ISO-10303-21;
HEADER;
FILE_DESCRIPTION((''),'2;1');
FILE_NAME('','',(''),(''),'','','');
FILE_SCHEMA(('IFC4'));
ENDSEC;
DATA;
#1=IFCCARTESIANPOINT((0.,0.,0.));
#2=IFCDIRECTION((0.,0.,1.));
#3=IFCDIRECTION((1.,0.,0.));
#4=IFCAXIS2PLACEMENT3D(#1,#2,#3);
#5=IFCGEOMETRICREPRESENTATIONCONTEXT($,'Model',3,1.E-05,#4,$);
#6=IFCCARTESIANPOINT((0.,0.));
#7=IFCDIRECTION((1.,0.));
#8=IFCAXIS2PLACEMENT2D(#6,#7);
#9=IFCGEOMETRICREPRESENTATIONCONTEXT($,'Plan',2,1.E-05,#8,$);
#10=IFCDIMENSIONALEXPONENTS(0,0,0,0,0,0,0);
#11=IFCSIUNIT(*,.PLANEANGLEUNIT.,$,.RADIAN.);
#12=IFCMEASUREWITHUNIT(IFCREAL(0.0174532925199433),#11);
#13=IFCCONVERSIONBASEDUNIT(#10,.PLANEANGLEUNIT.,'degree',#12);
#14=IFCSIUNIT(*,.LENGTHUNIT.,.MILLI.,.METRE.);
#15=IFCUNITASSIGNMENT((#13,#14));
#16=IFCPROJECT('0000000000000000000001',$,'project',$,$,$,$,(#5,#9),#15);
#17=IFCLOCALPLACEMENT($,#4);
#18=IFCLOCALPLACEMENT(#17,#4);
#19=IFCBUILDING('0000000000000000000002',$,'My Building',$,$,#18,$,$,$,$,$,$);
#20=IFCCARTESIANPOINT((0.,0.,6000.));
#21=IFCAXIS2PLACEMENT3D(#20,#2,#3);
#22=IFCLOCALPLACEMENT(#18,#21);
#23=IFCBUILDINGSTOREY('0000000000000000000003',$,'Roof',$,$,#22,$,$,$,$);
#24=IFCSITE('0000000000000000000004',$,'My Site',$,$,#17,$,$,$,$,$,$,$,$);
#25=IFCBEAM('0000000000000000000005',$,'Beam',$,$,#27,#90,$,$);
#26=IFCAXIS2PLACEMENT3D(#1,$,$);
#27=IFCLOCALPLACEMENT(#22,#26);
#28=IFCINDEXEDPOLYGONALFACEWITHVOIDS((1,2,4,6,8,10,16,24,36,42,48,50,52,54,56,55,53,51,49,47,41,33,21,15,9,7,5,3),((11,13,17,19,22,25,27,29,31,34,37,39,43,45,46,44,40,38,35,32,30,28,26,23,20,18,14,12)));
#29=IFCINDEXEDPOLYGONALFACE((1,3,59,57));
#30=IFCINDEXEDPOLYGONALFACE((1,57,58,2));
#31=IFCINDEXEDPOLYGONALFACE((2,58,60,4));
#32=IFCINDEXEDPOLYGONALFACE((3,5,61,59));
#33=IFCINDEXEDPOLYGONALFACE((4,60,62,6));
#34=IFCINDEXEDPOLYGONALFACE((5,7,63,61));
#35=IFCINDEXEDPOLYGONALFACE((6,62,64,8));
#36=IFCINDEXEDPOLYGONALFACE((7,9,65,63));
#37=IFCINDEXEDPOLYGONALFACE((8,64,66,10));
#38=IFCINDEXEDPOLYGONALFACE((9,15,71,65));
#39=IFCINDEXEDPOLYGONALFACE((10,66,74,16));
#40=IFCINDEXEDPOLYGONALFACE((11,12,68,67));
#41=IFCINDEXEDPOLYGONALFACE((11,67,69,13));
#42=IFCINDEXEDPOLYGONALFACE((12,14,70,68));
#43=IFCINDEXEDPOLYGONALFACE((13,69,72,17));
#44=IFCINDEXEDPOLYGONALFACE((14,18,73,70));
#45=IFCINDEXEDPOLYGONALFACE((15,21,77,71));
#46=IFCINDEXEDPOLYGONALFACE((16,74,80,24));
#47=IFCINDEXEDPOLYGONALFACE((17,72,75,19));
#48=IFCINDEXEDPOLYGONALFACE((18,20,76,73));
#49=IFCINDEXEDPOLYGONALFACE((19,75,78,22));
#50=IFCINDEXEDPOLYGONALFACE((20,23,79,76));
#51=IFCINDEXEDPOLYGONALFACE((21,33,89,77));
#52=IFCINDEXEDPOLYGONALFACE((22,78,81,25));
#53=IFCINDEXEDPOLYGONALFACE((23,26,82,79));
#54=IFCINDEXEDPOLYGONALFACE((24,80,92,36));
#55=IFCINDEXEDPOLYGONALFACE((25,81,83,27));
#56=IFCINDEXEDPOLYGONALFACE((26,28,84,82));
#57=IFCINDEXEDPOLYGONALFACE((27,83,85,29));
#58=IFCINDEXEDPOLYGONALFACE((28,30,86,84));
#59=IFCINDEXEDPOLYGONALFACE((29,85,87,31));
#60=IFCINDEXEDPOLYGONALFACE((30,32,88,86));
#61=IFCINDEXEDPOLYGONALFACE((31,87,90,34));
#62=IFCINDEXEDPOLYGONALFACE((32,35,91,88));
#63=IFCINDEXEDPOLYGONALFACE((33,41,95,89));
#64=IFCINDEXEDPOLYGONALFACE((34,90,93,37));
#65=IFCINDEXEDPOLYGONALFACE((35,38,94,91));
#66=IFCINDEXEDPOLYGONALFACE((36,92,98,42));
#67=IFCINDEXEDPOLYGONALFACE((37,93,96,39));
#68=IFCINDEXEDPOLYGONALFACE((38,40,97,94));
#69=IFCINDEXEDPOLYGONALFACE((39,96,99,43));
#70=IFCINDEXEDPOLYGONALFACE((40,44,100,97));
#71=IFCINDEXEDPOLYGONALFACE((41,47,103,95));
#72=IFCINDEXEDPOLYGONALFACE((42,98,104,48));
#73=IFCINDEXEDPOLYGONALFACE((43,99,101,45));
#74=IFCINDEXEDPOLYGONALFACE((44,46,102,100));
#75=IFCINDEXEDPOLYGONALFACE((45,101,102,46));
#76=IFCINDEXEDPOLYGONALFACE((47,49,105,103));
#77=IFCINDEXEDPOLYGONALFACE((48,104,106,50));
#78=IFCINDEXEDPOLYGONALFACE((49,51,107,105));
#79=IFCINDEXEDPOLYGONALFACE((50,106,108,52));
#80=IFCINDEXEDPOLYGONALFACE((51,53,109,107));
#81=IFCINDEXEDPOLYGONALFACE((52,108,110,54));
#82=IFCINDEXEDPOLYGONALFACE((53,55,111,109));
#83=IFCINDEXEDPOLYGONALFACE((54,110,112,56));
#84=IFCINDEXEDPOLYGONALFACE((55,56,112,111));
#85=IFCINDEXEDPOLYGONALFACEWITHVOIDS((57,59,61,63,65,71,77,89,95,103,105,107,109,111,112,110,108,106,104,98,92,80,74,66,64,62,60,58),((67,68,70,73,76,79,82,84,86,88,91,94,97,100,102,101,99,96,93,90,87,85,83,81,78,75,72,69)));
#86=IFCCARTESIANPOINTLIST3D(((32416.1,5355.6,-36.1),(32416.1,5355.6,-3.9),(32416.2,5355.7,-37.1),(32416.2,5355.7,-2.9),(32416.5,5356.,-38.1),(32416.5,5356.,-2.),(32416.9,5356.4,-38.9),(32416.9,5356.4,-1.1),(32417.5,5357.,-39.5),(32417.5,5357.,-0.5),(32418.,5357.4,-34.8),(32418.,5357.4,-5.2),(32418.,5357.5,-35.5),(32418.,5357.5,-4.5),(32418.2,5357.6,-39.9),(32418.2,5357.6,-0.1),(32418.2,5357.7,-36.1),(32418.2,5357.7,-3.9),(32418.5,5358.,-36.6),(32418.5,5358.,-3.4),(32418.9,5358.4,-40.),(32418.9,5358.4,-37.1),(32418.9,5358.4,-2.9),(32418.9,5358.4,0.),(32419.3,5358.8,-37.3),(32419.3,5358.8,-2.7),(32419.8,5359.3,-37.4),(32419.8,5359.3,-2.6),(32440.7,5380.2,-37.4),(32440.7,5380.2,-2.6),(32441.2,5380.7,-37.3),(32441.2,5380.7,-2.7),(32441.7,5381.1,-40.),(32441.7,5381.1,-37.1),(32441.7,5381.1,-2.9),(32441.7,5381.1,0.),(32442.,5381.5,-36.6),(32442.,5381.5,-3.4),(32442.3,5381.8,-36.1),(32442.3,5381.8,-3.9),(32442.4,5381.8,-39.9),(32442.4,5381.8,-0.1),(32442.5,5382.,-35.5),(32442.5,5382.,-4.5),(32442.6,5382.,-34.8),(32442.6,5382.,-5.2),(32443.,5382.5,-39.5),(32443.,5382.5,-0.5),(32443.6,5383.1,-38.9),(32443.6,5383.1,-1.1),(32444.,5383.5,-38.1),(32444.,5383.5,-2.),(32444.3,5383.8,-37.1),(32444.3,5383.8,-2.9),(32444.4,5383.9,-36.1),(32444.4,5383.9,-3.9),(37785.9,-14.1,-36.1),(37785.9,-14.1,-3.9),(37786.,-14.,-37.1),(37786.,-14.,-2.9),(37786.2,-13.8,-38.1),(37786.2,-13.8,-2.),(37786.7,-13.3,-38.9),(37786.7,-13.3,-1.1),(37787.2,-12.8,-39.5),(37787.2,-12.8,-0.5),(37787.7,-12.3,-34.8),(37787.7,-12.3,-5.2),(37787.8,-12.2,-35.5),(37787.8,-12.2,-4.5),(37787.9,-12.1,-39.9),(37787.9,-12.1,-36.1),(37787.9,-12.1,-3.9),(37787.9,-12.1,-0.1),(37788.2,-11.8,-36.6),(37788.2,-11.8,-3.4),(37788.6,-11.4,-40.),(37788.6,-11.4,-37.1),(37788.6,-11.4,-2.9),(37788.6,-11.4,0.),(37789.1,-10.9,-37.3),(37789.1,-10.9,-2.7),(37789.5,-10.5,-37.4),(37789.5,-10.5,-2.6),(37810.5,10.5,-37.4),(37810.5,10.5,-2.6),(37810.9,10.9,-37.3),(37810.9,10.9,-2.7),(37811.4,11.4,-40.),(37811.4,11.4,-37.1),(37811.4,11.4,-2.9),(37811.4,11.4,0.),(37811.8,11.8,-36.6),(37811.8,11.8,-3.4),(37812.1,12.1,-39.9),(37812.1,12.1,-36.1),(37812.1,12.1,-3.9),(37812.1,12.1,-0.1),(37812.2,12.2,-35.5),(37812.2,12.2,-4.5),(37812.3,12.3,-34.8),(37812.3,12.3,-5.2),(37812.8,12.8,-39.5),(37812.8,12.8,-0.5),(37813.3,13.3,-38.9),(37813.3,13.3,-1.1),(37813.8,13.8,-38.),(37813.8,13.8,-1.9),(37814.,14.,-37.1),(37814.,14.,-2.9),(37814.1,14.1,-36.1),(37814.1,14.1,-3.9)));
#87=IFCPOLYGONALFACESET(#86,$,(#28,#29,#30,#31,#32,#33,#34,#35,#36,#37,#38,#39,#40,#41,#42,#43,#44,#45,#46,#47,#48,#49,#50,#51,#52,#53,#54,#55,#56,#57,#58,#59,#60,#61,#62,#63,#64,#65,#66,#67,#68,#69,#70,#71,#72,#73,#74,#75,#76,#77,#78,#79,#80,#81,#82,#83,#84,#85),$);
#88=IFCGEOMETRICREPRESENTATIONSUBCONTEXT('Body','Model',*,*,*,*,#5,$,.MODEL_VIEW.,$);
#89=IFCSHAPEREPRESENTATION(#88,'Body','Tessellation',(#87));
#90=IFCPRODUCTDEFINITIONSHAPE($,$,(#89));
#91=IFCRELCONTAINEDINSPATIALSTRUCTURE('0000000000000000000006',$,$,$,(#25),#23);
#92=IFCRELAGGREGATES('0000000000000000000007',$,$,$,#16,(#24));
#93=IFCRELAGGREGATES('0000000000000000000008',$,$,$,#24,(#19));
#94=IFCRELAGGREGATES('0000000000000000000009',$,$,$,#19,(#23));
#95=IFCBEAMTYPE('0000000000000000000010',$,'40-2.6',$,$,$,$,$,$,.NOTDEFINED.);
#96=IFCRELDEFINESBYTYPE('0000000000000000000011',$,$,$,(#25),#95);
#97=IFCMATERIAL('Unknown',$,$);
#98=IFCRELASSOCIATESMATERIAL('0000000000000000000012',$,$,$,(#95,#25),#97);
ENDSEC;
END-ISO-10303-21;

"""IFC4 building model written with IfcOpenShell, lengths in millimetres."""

from ifc_helpers import new_model, entity, si_unit, converted_unit, frame, origin_with_axes, origin_2d_with_axis, place, context, subcontext, project, spatial, hollow_rectangle, extrude, material, material_profile, profile_set, profile_usage, type_object, element, save


model = new_model("IFC4")

# Units and contexts
model_context = context("Model", 3, precision=1e-05, world=origin_with_axes())
plan_context = context("Plan", 2, precision=1e-05, world=origin_2d_with_axis())
body_context = subcontext(model_context, "Body", "Model", "MODEL_VIEW")
ifc_project = project(units=[converted_unit("PLANEANGLEUNIT", "degree", entity("IfcReal", 0.0174532925199433), si_unit("PLANEANGLEUNIT", "RADIAN"), dimensions=[0, 0, 0, 0, 0, 0, 0]), si_unit("LENGTHUNIT", "METRE", prefix="MILLI")], contexts=[model_context, plan_context])

# Site, building, storey
site_placement = place(None, origin_with_axes())
site = spatial("IfcSite", under=ifc_project, at=site_placement, Name="My Site")
building_placement = place(site_placement, origin_with_axes())
building = spatial("IfcBuilding", under=site, at=building_placement, Name="My Building")
storey_placement = place(building_placement, frame((0.0, 0.0, 6000.0), z_axis=(0.0, 0.0, 1.0), x_axis=(1.0, 0.0, 0.0)))
storey = spatial("IfcBuildingStorey", under=building, at=storey_placement, Name="Roof")

# Beam
ifc_material = material(Name="Unknown")
ifc_material_profile_1 = material_profile(ifc_material, hollow_rectangle(XDim=40.0, YDim=40.0, WallThickness=2.6, InnerFilletRadius=2.6, OuterFilletRadius=3.9))
ifc_profile_set_1 = profile_set([ifc_material_profile_1])
beam_type_1 = type_object("IfcBeamType", Name="40-2.6", PredefinedType="NOTDEFINED", material=ifc_profile_set_1)
ifc_profile_usage_1 = profile_usage(ifc_profile_set_1, cardinal=8)
beam_1_placement = place(storey_placement, frame((37800.0, 0.0, 0.0), z_axis=(-0.707107, 0.707107, 0.0), x_axis=(-0.707107, -0.707107, 0.0)))
element("IfcBeam", 1, at=beam_1_placement, inside=storey, type_object=beam_type_1, material=ifc_profile_usage_1, Name="Beam", context=body_context, shape_type="SweptSolid", body=[
    extrude(hollow_rectangle(XDim=40.0, YDim=40.0, WallThickness=2.6, InnerFilletRadius=2.6, OuterFilletRadius=3.9), frame((0.0, -20.0, 0.0), z_axis=(0.0, 0.0, 1.0), x_axis=(1.0, 0.0, 0.0)), (0.0, 0.0, 1.0), 7594.0),
])

save(model, "model.ifc")
